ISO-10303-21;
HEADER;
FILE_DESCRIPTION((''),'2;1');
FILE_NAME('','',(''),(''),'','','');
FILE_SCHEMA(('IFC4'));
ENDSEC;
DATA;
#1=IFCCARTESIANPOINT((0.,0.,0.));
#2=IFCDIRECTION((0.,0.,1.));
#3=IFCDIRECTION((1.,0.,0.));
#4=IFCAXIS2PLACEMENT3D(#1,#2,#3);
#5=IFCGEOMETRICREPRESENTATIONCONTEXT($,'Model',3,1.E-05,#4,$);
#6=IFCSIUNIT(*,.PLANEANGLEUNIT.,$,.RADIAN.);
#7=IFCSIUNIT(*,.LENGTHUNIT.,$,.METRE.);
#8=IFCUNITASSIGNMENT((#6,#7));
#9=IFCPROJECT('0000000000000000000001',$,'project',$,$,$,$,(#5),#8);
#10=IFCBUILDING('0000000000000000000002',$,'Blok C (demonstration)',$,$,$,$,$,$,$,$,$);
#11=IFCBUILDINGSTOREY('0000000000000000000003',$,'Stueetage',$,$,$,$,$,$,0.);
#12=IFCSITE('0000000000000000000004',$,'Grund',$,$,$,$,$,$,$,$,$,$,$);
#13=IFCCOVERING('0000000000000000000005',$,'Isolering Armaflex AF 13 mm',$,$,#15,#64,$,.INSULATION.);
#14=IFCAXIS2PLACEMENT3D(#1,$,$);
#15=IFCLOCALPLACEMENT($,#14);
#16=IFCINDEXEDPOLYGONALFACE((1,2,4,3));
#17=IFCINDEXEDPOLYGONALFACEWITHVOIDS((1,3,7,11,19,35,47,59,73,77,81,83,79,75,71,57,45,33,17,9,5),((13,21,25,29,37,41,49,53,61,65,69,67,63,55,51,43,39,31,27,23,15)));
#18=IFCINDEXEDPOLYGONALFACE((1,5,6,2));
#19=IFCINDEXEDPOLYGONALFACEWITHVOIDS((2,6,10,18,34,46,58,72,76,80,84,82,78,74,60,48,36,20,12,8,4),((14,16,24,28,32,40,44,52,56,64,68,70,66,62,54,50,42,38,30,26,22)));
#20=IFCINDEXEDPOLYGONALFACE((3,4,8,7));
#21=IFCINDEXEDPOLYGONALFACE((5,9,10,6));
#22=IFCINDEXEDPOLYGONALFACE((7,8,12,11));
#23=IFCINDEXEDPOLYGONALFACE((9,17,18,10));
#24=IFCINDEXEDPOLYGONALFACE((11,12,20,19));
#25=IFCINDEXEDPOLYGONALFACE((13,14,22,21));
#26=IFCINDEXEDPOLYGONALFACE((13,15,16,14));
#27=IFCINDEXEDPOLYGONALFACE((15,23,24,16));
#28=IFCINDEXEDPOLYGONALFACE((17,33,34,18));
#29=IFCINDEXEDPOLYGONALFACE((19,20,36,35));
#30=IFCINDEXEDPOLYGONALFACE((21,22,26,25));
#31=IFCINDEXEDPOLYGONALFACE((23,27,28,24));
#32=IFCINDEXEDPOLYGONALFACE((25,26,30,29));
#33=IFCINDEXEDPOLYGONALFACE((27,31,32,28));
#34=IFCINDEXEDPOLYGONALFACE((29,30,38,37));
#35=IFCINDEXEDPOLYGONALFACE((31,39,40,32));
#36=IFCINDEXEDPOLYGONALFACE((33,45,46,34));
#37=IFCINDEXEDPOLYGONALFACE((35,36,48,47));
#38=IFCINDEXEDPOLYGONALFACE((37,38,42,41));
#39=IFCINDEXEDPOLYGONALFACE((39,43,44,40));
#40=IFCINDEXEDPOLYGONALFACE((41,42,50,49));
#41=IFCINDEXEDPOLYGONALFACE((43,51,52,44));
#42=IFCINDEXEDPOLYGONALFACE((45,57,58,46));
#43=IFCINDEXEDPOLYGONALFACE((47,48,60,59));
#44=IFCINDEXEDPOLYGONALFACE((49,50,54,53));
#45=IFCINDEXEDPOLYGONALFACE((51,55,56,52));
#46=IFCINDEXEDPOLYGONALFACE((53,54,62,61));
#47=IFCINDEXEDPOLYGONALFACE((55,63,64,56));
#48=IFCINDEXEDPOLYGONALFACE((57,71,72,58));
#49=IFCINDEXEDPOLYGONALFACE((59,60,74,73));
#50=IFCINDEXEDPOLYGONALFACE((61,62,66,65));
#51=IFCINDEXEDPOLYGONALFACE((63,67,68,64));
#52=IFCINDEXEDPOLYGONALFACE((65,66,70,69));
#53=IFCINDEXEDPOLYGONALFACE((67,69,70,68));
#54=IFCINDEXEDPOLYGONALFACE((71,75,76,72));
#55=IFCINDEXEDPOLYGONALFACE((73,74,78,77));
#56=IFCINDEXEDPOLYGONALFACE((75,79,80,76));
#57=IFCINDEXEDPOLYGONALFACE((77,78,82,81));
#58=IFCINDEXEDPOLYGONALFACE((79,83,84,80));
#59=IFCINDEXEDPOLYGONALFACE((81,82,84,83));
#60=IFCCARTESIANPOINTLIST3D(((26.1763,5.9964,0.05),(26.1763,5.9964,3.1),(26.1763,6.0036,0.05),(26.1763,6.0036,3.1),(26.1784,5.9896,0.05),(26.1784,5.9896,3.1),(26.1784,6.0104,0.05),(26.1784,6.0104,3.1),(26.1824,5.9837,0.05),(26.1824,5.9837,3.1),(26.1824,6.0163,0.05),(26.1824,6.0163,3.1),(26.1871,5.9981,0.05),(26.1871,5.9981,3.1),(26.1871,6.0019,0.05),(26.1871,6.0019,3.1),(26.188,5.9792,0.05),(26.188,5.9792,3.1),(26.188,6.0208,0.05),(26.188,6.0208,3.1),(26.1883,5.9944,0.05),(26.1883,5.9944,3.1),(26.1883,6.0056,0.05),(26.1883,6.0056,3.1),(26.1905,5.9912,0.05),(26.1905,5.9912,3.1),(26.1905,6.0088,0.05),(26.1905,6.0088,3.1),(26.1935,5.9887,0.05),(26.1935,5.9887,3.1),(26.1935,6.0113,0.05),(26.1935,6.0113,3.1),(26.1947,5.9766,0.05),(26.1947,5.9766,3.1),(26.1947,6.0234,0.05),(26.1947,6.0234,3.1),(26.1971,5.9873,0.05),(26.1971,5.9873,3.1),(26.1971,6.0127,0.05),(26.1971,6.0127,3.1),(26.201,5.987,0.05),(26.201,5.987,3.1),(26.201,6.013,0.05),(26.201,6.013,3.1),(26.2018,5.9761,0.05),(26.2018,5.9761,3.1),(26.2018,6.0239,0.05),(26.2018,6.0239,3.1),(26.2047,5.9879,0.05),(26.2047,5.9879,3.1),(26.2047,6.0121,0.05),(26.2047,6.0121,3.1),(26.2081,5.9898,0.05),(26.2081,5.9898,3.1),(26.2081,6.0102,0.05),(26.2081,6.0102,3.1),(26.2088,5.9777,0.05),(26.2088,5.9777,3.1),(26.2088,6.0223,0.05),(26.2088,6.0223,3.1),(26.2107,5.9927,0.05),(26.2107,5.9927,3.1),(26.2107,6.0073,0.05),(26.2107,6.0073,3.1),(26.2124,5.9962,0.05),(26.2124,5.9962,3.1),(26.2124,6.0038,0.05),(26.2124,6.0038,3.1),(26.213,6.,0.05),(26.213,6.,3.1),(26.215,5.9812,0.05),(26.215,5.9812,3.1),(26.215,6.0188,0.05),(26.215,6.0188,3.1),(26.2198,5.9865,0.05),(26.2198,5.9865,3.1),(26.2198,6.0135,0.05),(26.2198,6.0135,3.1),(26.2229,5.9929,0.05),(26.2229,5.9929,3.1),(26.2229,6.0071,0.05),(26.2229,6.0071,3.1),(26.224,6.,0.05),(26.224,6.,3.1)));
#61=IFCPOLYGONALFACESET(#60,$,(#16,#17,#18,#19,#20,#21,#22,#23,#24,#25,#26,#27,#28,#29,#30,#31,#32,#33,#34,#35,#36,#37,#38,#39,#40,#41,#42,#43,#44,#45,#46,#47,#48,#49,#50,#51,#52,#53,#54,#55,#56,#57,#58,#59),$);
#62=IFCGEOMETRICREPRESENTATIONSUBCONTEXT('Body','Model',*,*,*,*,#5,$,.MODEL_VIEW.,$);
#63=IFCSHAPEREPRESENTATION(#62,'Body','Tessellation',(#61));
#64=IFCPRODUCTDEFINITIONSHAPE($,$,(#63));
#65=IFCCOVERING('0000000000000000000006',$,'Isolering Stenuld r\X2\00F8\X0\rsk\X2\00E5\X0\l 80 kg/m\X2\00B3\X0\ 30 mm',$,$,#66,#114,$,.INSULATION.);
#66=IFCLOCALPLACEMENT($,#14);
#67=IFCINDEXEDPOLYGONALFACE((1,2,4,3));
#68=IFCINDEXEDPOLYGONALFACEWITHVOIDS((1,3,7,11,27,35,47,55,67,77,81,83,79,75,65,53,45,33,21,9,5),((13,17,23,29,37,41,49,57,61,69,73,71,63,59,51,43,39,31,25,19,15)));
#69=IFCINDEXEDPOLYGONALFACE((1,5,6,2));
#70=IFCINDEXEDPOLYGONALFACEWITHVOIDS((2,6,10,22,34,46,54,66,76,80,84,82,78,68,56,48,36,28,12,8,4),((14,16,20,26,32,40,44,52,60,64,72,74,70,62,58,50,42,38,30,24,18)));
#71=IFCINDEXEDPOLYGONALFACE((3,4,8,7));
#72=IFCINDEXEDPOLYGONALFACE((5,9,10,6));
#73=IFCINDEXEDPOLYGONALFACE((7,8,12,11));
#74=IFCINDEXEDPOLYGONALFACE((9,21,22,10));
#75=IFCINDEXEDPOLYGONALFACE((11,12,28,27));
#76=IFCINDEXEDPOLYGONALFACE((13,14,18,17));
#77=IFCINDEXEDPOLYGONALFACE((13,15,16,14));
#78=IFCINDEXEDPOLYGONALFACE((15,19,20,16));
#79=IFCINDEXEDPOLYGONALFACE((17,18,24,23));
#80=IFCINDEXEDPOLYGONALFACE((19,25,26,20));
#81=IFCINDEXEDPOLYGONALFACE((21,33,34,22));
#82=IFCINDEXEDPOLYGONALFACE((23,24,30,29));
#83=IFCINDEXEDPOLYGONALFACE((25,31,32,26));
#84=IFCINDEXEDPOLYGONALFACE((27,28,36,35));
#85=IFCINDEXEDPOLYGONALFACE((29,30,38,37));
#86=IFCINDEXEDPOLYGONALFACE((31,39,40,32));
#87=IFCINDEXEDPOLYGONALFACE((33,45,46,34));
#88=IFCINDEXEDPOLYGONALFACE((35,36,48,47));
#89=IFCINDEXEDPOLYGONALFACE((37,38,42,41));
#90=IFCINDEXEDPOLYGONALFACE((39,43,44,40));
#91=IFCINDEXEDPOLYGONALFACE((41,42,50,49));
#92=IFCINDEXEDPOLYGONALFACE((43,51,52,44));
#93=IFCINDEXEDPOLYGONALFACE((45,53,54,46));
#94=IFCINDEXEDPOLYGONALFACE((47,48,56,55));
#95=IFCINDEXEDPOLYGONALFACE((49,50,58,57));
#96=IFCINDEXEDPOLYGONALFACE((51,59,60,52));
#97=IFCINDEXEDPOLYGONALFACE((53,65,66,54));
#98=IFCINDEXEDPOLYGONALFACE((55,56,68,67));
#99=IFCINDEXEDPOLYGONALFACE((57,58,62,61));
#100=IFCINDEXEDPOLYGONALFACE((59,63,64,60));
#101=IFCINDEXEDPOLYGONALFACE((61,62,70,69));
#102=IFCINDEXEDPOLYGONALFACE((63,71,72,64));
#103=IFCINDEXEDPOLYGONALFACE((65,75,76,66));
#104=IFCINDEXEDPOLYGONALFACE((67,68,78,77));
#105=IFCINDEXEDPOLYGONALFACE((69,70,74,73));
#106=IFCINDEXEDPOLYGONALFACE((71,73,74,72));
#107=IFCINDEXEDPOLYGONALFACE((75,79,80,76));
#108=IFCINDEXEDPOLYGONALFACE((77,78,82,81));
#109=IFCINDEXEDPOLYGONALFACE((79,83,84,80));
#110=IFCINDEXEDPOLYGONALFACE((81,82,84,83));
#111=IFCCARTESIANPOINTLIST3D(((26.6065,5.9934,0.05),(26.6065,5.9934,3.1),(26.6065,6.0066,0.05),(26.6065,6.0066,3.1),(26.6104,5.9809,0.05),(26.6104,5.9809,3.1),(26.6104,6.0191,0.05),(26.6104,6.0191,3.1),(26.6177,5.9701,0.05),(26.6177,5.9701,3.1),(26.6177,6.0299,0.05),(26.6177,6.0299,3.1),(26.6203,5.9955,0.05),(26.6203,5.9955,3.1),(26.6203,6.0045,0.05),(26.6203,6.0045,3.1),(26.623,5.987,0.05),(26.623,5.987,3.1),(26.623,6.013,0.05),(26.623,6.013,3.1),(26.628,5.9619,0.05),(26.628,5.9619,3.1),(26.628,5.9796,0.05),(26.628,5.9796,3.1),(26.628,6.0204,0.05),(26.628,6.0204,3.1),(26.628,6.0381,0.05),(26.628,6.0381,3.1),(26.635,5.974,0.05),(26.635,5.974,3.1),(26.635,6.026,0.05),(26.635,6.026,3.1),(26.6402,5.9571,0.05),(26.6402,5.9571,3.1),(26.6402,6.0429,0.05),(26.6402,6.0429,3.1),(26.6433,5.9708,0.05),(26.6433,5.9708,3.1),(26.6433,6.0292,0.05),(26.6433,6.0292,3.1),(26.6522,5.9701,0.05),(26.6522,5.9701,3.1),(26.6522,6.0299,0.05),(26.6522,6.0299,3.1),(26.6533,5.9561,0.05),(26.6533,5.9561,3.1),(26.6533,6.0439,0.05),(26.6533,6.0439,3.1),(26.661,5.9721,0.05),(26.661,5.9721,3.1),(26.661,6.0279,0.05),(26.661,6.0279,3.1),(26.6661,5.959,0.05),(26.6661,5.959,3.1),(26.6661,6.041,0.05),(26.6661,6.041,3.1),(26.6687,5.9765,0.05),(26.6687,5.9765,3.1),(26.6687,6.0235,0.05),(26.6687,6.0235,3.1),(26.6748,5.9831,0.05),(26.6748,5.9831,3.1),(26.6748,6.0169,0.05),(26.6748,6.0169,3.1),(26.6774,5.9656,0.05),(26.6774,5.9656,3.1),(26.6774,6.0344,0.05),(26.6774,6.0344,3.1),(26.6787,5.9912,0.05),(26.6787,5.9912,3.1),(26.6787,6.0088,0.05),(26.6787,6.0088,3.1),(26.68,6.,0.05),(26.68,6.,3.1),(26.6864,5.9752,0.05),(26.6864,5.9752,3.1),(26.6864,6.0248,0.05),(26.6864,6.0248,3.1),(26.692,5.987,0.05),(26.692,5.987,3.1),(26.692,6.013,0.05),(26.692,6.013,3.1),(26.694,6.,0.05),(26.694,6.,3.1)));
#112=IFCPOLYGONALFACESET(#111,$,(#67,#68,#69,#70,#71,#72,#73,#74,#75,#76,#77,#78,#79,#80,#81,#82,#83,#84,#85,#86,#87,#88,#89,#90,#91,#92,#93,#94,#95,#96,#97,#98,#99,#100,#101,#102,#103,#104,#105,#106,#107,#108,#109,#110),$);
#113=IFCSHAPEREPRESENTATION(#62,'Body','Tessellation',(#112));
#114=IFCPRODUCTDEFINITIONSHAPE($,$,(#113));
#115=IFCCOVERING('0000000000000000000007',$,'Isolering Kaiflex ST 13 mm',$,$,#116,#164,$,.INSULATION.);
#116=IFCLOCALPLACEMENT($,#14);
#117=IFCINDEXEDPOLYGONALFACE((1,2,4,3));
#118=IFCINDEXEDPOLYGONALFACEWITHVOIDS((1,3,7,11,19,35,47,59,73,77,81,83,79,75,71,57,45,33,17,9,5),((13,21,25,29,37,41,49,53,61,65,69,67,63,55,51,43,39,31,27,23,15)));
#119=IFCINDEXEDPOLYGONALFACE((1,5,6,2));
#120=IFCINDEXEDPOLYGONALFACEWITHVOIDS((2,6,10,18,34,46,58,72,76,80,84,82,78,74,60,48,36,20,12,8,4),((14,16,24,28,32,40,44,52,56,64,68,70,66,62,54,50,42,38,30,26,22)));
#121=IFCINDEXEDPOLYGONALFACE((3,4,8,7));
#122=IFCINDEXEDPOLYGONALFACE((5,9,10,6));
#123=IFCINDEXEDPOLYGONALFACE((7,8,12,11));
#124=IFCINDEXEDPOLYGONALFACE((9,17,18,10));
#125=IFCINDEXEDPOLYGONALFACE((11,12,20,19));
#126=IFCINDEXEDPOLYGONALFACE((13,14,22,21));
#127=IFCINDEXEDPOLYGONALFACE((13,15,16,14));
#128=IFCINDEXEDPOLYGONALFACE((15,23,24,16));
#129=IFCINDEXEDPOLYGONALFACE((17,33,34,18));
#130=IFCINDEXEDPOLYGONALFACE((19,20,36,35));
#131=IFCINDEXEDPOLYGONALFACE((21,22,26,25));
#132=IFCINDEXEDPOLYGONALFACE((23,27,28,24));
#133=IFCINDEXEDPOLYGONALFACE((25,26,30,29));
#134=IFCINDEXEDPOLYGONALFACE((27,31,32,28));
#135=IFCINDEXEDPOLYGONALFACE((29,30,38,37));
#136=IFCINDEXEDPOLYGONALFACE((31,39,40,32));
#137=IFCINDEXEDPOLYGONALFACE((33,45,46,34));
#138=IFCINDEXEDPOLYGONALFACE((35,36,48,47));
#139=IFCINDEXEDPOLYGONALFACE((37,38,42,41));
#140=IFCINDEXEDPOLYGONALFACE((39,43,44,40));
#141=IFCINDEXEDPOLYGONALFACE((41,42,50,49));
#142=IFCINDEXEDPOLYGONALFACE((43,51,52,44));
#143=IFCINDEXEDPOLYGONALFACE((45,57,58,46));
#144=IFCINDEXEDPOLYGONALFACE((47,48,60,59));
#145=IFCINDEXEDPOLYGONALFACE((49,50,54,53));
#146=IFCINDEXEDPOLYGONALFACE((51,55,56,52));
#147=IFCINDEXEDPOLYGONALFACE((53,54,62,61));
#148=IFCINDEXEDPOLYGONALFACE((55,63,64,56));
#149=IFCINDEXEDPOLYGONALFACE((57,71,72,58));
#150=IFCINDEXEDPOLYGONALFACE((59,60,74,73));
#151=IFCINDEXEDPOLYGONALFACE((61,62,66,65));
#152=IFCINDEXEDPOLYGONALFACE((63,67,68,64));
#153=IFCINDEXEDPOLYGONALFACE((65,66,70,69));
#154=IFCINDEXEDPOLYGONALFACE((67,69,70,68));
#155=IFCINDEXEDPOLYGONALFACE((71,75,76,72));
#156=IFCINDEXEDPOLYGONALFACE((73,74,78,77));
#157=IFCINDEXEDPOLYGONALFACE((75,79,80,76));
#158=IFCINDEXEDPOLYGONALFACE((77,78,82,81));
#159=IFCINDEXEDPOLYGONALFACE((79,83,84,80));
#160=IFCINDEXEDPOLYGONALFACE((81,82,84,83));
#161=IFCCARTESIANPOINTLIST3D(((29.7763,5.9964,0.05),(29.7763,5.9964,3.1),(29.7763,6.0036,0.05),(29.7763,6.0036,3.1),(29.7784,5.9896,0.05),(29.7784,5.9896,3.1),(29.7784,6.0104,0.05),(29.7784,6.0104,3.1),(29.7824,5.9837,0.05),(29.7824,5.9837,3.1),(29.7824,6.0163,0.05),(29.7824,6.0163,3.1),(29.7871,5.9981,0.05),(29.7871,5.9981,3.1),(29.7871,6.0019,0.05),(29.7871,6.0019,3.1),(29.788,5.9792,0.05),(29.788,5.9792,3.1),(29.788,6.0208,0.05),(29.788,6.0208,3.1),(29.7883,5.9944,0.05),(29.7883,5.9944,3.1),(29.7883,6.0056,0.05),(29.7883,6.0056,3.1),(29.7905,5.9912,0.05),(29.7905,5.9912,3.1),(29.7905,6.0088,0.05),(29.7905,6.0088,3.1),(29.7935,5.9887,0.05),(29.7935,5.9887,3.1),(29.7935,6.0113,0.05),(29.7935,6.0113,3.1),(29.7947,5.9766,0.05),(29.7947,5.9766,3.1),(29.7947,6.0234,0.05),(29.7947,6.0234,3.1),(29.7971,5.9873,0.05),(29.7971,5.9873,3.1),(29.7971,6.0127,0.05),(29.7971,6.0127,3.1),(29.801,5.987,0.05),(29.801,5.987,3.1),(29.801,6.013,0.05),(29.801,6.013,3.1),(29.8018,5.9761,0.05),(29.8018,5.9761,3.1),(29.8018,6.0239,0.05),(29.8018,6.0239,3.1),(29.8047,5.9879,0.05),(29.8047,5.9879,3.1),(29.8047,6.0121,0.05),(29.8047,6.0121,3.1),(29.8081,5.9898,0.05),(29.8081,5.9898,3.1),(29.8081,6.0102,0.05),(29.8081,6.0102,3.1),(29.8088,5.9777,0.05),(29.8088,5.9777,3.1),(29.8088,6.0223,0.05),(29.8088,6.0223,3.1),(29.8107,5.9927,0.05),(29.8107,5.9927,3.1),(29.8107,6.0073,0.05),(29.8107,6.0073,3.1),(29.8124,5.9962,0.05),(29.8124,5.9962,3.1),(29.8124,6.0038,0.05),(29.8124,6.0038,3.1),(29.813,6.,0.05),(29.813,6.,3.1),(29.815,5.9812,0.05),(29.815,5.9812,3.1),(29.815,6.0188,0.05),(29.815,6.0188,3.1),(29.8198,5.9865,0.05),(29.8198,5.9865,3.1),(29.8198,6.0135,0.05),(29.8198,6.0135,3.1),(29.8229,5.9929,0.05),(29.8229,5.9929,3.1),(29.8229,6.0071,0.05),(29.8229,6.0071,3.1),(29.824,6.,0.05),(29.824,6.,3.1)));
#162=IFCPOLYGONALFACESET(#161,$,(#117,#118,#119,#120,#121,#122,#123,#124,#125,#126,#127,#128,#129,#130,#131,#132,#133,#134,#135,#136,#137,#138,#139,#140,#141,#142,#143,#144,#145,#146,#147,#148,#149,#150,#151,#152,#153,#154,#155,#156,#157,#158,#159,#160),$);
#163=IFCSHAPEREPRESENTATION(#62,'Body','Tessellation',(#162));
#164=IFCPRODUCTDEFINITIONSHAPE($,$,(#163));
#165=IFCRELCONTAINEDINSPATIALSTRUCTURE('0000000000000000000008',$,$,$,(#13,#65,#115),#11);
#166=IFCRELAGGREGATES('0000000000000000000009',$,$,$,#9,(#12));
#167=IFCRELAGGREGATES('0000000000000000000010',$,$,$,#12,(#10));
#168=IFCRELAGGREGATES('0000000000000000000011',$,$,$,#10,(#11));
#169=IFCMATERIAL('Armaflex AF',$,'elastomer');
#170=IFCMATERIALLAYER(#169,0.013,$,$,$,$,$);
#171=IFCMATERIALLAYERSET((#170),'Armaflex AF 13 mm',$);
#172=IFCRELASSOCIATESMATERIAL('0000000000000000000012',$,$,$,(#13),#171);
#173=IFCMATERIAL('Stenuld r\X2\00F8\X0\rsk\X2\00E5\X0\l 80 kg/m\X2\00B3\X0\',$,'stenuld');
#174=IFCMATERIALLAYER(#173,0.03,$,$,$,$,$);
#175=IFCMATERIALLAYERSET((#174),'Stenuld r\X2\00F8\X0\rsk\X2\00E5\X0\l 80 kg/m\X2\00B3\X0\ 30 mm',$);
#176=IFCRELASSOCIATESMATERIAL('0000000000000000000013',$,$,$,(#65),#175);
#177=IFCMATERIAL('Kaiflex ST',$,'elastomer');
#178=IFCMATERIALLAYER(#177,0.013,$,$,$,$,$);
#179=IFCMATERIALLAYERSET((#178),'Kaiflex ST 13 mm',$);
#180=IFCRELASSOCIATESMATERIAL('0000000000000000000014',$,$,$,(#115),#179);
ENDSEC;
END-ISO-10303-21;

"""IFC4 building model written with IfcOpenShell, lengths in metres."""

from ifc_helpers import new_model, si_unit, frame, origin_with_axes, place, context, subcontext, project, spatial, hollow_circle, extrude, material, layer, layer_set, element, save


model = new_model("IFC4")

# Units and contexts
model_context = context("Model", 3, precision=1e-05, world=origin_with_axes())
body_context = subcontext(model_context, "Body", "Model", "MODEL_VIEW")
ifc_project = project(units=[si_unit("PLANEANGLEUNIT", "RADIAN"), si_unit("LENGTHUNIT", "METRE")], contexts=[model_context])

# Site, building, storey
site = spatial("IfcSite", under=ifc_project, Name="Grund")
building = spatial("IfcBuilding", under=site, Name="Blok C (demonstration)")
storey = spatial("IfcBuildingStorey", under=building, Name="Stueetage", Elevation=0.0)

# Coverings
ifc_material_1 = material(Name="Armaflex AF", Category="elastomer")
ifc_layer_1 = layer(ifc_material_1, 0.013)
ifc_layer_set_1 = layer_set([ifc_layer_1], Name="Armaflex AF 13 mm")
covering_1_placement = place(None, origin_with_axes())
element("IfcCovering", 1, at=covering_1_placement, inside=storey, material=ifc_layer_set_1, Name="Isolering Armaflex AF 13 mm", PredefinedType="INSULATION", context=body_context, shape_type="SweptSolid", body=[
    extrude(hollow_circle(Radius=0.024, WallThickness=0.011), frame((26.2, 6.0, 0.05), z_axis=(0.0, 0.0, 1.0), x_axis=(1.0, 0.0, 0.0)), (0.0, 0.0, 1.0), 3.05),
])
ifc_material_2 = material(Name="Stenuld rørskål 80 kg/m³", Category="stenuld")
ifc_layer_2 = layer(ifc_material_2, 0.03)
ifc_layer_set_2 = layer_set([ifc_layer_2], Name="Stenuld rørskål 80 kg/m³ 30 mm")
covering_2_placement = place(None, origin_with_axes())
element("IfcCovering", 2, at=covering_2_placement, inside=storey, material=ifc_layer_set_2, Name="Isolering Stenuld rørskål 80 kg/m³ 30 mm", PredefinedType="INSULATION", context=body_context, shape_type="SweptSolid", body=[
    extrude(hollow_circle(Radius=0.044, WallThickness=0.014), frame((26.65, 6.0, 0.05), z_axis=(0.0, 0.0, 1.0), x_axis=(1.0, 0.0, 0.0)), (0.0, 0.0, 1.0), 3.05),
])
ifc_material_3 = material(Name="Kaiflex ST", Category="elastomer")
ifc_layer_3 = layer(ifc_material_3, 0.013)
ifc_layer_set_3 = layer_set([ifc_layer_3], Name="Kaiflex ST 13 mm")
covering_3_placement = place(None, origin_with_axes())
element("IfcCovering", 3, at=covering_3_placement, inside=storey, material=ifc_layer_set_3, Name="Isolering Kaiflex ST 13 mm", PredefinedType="INSULATION", context=body_context, shape_type="SweptSolid", body=[
    extrude(hollow_circle(Radius=0.024, WallThickness=0.011), frame((29.8, 6.0, 0.05), z_axis=(0.0, 0.0, 1.0), x_axis=(1.0, 0.0, 0.0)), (0.0, 0.0, 1.0), 3.05),
])

save(model, "model.ifc")
